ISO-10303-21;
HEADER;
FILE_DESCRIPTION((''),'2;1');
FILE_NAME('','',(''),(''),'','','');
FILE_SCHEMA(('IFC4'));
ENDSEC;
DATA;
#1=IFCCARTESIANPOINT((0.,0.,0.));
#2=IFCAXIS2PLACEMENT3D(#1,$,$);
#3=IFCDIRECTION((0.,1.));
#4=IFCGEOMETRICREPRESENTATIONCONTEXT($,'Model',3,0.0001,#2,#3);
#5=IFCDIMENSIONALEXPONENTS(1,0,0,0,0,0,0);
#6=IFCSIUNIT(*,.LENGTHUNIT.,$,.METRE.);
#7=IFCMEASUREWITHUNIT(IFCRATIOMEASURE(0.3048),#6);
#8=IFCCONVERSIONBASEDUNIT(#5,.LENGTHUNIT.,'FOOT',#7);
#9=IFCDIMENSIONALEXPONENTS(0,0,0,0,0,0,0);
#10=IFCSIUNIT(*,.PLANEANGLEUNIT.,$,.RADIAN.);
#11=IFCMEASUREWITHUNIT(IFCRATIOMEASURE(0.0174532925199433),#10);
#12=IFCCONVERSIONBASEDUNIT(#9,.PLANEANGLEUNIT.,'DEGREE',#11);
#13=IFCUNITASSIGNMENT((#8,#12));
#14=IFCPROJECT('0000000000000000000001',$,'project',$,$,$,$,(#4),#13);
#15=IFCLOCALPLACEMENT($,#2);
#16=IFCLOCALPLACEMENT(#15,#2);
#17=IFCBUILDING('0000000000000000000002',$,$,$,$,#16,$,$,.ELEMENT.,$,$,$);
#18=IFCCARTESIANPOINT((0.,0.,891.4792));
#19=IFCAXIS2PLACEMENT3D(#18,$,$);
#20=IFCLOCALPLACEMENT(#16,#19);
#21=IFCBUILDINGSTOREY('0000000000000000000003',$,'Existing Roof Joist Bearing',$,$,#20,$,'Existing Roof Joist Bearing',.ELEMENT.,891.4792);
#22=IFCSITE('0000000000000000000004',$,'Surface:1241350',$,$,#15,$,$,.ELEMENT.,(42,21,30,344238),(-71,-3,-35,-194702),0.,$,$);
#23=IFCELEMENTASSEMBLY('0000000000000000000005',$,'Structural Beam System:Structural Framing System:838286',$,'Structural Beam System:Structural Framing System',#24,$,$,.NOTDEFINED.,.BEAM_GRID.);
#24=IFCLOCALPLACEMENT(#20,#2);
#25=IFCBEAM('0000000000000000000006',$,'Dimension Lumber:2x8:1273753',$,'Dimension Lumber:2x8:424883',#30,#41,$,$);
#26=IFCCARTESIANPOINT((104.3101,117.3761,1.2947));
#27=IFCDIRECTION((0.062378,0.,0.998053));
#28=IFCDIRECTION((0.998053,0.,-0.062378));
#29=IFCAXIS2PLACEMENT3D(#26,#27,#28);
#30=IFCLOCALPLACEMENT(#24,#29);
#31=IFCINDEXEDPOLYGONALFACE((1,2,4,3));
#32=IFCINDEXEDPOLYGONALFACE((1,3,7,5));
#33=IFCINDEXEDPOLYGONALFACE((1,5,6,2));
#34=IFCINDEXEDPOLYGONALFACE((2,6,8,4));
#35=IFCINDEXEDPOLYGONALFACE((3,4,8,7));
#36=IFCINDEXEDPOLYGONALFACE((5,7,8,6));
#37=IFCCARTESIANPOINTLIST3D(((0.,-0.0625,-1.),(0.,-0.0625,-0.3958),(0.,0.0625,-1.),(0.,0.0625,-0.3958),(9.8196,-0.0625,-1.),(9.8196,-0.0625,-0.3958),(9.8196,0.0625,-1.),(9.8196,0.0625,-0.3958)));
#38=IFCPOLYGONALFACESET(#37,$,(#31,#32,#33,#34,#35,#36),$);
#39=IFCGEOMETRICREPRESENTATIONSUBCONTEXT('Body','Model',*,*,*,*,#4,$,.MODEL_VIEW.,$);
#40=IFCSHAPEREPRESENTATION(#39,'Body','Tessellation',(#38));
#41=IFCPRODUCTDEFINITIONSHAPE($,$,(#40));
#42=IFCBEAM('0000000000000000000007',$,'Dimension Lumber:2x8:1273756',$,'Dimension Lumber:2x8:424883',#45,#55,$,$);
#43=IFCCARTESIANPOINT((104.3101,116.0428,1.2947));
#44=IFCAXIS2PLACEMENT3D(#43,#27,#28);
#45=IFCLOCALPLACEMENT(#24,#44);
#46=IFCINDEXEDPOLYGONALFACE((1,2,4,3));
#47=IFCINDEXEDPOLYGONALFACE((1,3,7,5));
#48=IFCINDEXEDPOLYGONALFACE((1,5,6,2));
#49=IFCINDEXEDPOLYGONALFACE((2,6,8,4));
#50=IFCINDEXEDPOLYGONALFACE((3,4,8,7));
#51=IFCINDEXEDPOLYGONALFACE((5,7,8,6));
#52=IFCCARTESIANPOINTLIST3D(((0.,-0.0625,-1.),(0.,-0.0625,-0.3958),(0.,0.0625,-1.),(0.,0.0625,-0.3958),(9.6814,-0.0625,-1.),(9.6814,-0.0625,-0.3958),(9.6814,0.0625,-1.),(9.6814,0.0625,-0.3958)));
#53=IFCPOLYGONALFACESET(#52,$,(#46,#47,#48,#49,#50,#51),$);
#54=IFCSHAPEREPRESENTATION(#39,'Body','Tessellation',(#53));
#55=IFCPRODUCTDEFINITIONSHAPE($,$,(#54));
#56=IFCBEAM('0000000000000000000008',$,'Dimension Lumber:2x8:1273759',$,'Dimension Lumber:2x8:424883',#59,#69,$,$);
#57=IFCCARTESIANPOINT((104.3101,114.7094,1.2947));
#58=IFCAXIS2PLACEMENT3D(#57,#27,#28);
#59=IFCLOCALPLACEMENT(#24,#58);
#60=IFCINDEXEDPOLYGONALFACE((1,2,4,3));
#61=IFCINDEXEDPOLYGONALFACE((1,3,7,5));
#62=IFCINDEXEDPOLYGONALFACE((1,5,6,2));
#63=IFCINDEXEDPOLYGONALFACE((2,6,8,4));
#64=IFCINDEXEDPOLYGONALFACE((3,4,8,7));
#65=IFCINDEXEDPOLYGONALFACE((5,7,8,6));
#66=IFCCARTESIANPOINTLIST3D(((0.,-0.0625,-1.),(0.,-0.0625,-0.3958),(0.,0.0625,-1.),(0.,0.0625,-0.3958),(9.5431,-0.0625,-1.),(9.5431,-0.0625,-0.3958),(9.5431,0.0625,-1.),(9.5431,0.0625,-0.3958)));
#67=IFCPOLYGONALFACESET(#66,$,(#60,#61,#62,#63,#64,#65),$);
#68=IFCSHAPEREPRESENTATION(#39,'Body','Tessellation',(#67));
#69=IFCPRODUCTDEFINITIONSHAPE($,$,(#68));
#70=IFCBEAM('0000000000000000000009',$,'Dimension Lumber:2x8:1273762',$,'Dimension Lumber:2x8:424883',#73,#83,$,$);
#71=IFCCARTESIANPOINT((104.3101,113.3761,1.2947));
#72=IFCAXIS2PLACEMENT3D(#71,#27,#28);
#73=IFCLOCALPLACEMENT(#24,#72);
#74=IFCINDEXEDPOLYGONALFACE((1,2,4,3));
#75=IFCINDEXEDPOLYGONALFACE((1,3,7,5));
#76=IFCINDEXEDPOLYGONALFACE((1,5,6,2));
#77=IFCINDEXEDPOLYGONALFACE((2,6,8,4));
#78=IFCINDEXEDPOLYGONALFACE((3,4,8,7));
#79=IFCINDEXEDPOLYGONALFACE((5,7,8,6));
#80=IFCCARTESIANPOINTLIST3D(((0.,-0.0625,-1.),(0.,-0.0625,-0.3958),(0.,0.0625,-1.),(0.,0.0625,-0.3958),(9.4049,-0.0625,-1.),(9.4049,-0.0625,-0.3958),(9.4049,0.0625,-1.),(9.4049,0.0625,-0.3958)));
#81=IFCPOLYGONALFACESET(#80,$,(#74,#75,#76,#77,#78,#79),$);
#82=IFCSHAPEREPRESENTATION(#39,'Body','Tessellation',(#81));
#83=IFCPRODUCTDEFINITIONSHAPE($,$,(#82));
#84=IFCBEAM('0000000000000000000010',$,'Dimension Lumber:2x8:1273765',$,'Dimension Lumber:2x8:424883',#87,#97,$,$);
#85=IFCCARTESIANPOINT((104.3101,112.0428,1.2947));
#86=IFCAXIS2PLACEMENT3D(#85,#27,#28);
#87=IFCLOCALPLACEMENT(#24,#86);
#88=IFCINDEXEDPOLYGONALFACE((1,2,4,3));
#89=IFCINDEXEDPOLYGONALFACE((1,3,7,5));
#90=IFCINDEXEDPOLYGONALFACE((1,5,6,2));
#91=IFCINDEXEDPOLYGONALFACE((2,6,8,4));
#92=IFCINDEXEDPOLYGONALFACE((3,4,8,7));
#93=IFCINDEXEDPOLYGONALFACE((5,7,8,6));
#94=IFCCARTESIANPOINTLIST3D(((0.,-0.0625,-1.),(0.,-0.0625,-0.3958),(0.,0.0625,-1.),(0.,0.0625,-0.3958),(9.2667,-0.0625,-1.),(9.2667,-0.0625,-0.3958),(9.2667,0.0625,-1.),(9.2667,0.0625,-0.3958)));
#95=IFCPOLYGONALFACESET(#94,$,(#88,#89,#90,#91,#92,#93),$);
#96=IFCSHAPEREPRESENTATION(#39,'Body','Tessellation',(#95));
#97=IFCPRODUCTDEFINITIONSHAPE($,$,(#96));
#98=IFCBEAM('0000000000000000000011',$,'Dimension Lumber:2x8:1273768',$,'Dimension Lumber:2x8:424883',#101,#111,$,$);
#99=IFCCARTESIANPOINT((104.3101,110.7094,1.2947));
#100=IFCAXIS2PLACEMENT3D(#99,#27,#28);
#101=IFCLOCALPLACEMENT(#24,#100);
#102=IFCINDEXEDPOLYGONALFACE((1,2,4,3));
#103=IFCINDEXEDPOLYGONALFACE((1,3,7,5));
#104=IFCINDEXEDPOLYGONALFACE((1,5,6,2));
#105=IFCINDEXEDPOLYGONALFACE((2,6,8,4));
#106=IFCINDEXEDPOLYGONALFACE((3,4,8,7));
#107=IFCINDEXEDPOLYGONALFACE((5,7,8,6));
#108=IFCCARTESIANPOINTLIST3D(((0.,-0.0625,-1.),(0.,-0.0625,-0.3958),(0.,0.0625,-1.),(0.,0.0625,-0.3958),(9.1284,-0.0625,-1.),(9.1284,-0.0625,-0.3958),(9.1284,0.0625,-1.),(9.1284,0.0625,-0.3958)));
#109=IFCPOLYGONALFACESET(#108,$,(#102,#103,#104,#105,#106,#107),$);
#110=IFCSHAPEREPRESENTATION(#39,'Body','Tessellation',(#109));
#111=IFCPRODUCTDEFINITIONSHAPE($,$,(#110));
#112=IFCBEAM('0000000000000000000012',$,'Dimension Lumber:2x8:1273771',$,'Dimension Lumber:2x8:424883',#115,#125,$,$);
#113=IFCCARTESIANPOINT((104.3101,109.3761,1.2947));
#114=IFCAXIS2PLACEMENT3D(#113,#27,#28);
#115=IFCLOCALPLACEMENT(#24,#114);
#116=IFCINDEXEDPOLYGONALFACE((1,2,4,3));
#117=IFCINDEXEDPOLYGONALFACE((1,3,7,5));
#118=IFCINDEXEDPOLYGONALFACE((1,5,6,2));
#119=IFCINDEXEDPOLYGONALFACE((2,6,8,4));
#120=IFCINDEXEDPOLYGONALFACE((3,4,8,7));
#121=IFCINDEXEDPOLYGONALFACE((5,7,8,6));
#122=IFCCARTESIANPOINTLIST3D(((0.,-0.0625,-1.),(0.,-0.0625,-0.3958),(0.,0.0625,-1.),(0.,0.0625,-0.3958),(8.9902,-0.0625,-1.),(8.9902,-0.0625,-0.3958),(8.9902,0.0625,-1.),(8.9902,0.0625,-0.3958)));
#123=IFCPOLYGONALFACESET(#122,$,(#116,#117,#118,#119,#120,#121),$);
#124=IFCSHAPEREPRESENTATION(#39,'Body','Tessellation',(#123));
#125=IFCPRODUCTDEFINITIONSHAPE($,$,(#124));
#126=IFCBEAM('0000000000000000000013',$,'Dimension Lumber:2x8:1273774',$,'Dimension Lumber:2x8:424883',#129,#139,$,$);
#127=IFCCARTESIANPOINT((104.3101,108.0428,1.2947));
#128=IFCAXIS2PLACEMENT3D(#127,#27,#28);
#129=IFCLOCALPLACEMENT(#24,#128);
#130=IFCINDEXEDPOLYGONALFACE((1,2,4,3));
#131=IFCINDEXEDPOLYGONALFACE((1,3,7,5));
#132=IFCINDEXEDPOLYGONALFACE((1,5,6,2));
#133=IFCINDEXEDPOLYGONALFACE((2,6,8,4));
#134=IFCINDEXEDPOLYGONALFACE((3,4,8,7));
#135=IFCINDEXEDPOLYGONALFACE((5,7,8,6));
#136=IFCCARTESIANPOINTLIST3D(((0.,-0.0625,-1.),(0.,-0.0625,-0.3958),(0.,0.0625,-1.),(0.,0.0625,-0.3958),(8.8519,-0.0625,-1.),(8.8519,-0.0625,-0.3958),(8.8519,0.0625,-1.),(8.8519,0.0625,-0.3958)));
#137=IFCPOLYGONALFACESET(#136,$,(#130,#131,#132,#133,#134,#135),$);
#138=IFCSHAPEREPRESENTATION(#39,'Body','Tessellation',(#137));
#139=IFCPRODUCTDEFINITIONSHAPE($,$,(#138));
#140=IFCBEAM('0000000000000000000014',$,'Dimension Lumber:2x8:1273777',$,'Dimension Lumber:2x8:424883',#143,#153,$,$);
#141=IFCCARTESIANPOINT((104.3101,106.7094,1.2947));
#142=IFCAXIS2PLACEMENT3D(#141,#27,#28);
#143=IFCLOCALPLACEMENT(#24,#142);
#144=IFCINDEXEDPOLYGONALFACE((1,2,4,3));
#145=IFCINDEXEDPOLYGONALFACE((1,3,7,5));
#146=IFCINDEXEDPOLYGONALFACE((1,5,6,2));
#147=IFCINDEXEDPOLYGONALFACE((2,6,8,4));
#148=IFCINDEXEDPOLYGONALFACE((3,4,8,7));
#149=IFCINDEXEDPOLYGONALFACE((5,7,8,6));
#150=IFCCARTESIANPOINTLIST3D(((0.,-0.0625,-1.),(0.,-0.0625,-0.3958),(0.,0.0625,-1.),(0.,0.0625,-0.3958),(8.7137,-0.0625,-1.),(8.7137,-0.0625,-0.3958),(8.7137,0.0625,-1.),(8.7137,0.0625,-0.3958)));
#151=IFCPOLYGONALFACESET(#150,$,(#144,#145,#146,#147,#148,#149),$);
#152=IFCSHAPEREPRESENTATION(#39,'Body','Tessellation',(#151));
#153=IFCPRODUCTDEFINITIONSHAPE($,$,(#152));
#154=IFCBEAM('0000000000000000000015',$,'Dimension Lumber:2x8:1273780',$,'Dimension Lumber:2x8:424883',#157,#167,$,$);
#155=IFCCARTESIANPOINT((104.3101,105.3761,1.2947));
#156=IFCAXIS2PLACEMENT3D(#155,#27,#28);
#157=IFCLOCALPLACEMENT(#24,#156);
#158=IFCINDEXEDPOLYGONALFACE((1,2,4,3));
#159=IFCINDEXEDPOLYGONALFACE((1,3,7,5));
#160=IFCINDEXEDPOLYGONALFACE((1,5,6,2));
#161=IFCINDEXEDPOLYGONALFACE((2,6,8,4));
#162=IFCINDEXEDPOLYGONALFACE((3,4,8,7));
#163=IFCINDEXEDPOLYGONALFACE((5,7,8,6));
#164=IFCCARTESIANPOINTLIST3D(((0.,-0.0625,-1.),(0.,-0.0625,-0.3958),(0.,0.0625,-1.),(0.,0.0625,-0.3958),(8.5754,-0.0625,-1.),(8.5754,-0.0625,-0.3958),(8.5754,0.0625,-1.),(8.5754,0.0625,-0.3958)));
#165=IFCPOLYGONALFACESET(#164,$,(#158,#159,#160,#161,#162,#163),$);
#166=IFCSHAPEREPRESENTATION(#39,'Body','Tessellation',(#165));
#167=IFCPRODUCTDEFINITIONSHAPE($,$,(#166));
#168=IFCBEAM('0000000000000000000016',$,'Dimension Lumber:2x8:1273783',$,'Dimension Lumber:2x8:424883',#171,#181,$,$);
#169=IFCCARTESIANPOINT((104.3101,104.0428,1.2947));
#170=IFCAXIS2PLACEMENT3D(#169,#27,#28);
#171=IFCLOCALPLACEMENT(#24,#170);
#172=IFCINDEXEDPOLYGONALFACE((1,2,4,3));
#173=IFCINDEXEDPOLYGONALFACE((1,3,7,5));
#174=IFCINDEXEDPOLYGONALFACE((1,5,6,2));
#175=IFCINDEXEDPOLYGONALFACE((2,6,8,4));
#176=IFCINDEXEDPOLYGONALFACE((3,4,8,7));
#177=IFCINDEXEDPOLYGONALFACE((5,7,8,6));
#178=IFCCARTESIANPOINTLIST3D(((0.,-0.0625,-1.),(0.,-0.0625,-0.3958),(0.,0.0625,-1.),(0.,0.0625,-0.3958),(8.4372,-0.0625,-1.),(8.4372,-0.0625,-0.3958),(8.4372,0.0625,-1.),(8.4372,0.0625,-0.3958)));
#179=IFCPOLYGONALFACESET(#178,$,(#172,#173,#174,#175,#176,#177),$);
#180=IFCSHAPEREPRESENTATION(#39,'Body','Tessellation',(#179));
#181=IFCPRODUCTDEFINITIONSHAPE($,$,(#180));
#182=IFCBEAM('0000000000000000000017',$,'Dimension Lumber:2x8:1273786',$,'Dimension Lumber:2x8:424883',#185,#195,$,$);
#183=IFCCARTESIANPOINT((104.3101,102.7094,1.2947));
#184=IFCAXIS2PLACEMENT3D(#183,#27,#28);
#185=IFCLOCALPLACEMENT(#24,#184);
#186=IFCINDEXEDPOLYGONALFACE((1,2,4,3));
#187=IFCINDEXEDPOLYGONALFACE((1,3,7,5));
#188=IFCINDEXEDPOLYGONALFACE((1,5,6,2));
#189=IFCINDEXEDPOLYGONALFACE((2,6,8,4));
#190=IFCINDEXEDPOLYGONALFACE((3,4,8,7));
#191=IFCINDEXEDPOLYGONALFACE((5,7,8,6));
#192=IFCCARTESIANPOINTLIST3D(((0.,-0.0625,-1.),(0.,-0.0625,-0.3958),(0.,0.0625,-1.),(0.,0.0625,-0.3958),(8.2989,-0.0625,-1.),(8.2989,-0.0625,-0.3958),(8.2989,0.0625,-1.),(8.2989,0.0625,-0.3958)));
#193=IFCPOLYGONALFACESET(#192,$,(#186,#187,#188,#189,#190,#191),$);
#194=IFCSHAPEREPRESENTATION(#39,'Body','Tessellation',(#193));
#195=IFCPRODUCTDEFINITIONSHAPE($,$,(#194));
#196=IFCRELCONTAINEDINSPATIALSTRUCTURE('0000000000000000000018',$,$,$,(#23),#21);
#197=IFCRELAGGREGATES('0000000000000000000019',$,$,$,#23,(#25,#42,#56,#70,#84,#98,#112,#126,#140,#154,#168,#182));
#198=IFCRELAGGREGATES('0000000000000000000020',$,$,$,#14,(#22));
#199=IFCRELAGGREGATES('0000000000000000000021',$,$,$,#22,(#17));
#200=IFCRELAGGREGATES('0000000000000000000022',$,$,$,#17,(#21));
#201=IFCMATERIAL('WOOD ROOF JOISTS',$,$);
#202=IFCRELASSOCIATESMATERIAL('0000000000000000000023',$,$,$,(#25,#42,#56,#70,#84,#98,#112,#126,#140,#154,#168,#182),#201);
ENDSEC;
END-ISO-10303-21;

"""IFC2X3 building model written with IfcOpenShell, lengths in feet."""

from ifc_helpers import new_model, entity, si_unit, converted_unit, direction, frame, frame_2d, origin, place, context, subcontext, project, spatial, rectangle, extrude, material, element, aggregate, save


model = new_model("IFC2X3")

# Units and contexts
model_context = context("Model", 3, precision=0.0001, world=origin(), true_north=direction((0.0, 1.0)))
body_context = subcontext(model_context, "Body", "Model", "MODEL_VIEW")
ifc_project = project(units=[converted_unit("LENGTHUNIT", "FOOT", entity("IfcRatioMeasure", 0.3048), si_unit("LENGTHUNIT", "METRE"), dimensions=[1, 0, 0, 0, 0, 0, 0]), converted_unit("PLANEANGLEUNIT", "DEGREE", entity("IfcRatioMeasure", 0.0174532925199433), si_unit("PLANEANGLEUNIT", "RADIAN"), dimensions=[0, 0, 0, 0, 0, 0, 0])], contexts=[model_context])

# Site, building, storey
site_placement = place(None, origin())
site = spatial("IfcSite", under=ifc_project, at=site_placement, Name="Surface:1241350", CompositionType="ELEMENT", RefLatitude=(42, 21, 30, 344238), RefLongitude=(-71, -3, -35, -194702), RefElevation=0.0)
building_placement = place(site_placement, origin())
building = spatial("IfcBuilding", under=site, at=building_placement, CompositionType="ELEMENT")
storey_placement = place(building_placement, frame((0.0, 0.0, 891.4792)))
storey = spatial("IfcBuildingStorey", under=building, at=storey_placement, Name="Existing Roof Joist Bearing", LongName="Existing Roof Joist Bearing", CompositionType="ELEMENT", Elevation=891.4792)

# Element assembly, beams
assembly_1_placement = place(storey_placement, origin())
assembly_1 = element("IfcElementAssembly", 1, at=assembly_1_placement, inside=storey, Name="Structural Beam System:Structural Framing System:838286", ObjectType="Structural Beam System:Structural Framing System", AssemblyPlace="NOTDEFINED", PredefinedType="BEAM_GRID")
ifc_material_1 = material(Name="WOOD ROOF JOISTS")
beam_1_placement = place(assembly_1_placement, frame((104.3101, 117.3761, 1.2947), z_axis=(0.062378, 0.0, 0.998053), x_axis=(0.998053, 0.0, -0.062378)))
beam_1 = element("IfcBeam", 2, at=beam_1_placement, material=ifc_material_1, Name="Dimension Lumber:2x8:1273753", ObjectType="Dimension Lumber:2x8:424883", context=body_context, shape_type="SweptSolid", body=[
    extrude(rectangle(XDim=0.6042, YDim=0.125, at=frame_2d((0.0, 0.0), x_axis=(1.0, 0.0))), frame((0.0, 0.0, -0.6979), z_axis=(1.0, 0.0, 0.0), x_axis=(0.0, 0.0, -1.0)), (0.0, 0.0, 1.0), 9.8196),
])
beam_2_placement = place(assembly_1_placement, frame((104.3101, 116.0428, 1.2947), z_axis=(0.062378, 0.0, 0.998053), x_axis=(0.998053, 0.0, -0.062378)))
beam_2 = element("IfcBeam", 3, at=beam_2_placement, material=ifc_material_1, Name="Dimension Lumber:2x8:1273756", ObjectType="Dimension Lumber:2x8:424883", context=body_context, shape_type="SweptSolid", body=[
    extrude(rectangle(XDim=0.6042, YDim=0.125, at=frame_2d((0.0, 0.0), x_axis=(1.0, 0.0))), frame((0.0, 0.0, -0.6979), z_axis=(1.0, 0.0, 0.0), x_axis=(0.0, 0.0, -1.0)), (0.0, 0.0, 1.0), 9.6814),
])
beam_3_placement = place(assembly_1_placement, frame((104.3101, 114.7094, 1.2947), z_axis=(0.062378, 0.0, 0.998053), x_axis=(0.998053, 0.0, -0.062378)))
beam_3 = element("IfcBeam", 4, at=beam_3_placement, material=ifc_material_1, Name="Dimension Lumber:2x8:1273759", ObjectType="Dimension Lumber:2x8:424883", context=body_context, shape_type="SweptSolid", body=[
    extrude(rectangle(XDim=0.6042, YDim=0.125, at=frame_2d((0.0, 0.0), x_axis=(1.0, 0.0))), frame((0.0, 0.0, -0.6979), z_axis=(1.0, 0.0, 0.0), x_axis=(0.0, 0.0, -1.0)), (0.0, 0.0, 1.0), 9.5431),
])
beam_4_placement = place(assembly_1_placement, frame((104.3101, 113.3761, 1.2947), z_axis=(0.062378, 0.0, 0.998053), x_axis=(0.998053, 0.0, -0.062378)))
beam_4 = element("IfcBeam", 5, at=beam_4_placement, material=ifc_material_1, Name="Dimension Lumber:2x8:1273762", ObjectType="Dimension Lumber:2x8:424883", context=body_context, shape_type="SweptSolid", body=[
    extrude(rectangle(XDim=0.6042, YDim=0.125, at=frame_2d((0.0, 0.0), x_axis=(1.0, 0.0))), frame((0.0, 0.0, -0.6979), z_axis=(1.0, 0.0, 0.0), x_axis=(0.0, 0.0, -1.0)), (0.0, 0.0, 1.0), 9.4049),
])
beam_5_placement = place(assembly_1_placement, frame((104.3101, 112.0428, 1.2947), z_axis=(0.062378, 0.0, 0.998053), x_axis=(0.998053, 0.0, -0.062378)))
beam_5 = element("IfcBeam", 6, at=beam_5_placement, material=ifc_material_1, Name="Dimension Lumber:2x8:1273765", ObjectType="Dimension Lumber:2x8:424883", context=body_context, shape_type="SweptSolid", body=[
    extrude(rectangle(XDim=0.6042, YDim=0.125, at=frame_2d((0.0, 0.0), x_axis=(1.0, 0.0))), frame((0.0, 0.0, -0.6979), z_axis=(1.0, 0.0, 0.0), x_axis=(0.0, 0.0, -1.0)), (0.0, 0.0, 1.0), 9.2667),
])
beam_6_placement = place(assembly_1_placement, frame((104.3101, 110.7094, 1.2947), z_axis=(0.062378, 0.0, 0.998053), x_axis=(0.998053, 0.0, -0.062378)))
beam_6 = element("IfcBeam", 7, at=beam_6_placement, material=ifc_material_1, Name="Dimension Lumber:2x8:1273768", ObjectType="Dimension Lumber:2x8:424883", context=body_context, shape_type="SweptSolid", body=[
    extrude(rectangle(XDim=0.6042, YDim=0.125, at=frame_2d((0.0, 0.0), x_axis=(1.0, 0.0))), frame((0.0, 0.0, -0.6979), z_axis=(1.0, 0.0, 0.0), x_axis=(0.0, 0.0, -1.0)), (0.0, 0.0, 1.0), 9.1284),
])
beam_7_placement = place(assembly_1_placement, frame((104.3101, 109.3761, 1.2947), z_axis=(0.062378, 0.0, 0.998053), x_axis=(0.998053, 0.0, -0.062378)))
beam_7 = element("IfcBeam", 8, at=beam_7_placement, material=ifc_material_1, Name="Dimension Lumber:2x8:1273771", ObjectType="Dimension Lumber:2x8:424883", context=body_context, shape_type="SweptSolid", body=[
    extrude(rectangle(XDim=0.6042, YDim=0.125, at=frame_2d((0.0, 0.0), x_axis=(1.0, 0.0))), frame((0.0, 0.0, -0.6979), z_axis=(1.0, 0.0, 0.0), x_axis=(0.0, 0.0, -1.0)), (0.0, 0.0, 1.0), 8.9902),
])
beam_8_placement = place(assembly_1_placement, frame((104.3101, 108.0428, 1.2947), z_axis=(0.062378, 0.0, 0.998053), x_axis=(0.998053, 0.0, -0.062378)))
beam_8 = element("IfcBeam", 9, at=beam_8_placement, material=ifc_material_1, Name="Dimension Lumber:2x8:1273774", ObjectType="Dimension Lumber:2x8:424883", context=body_context, shape_type="SweptSolid", body=[
    extrude(rectangle(XDim=0.6042, YDim=0.125, at=frame_2d((0.0, 0.0), x_axis=(1.0, 0.0))), frame((0.0, 0.0, -0.6979), z_axis=(1.0, 0.0, 0.0), x_axis=(0.0, 0.0, -1.0)), (0.0, 0.0, 1.0), 8.8519),
])
beam_9_placement = place(assembly_1_placement, frame((104.3101, 106.7094, 1.2947), z_axis=(0.062378, 0.0, 0.998053), x_axis=(0.998053, 0.0, -0.062378)))
beam_9 = element("IfcBeam", 10, at=beam_9_placement, material=ifc_material_1, Name="Dimension Lumber:2x8:1273777", ObjectType="Dimension Lumber:2x8:424883", context=body_context, shape_type="SweptSolid", body=[
    extrude(rectangle(XDim=0.6042, YDim=0.125, at=frame_2d((0.0, 0.0), x_axis=(1.0, 0.0))), frame((0.0, 0.0, -0.6979), z_axis=(1.0, 0.0, 0.0), x_axis=(0.0, 0.0, -1.0)), (0.0, 0.0, 1.0), 8.7137),
])
beam_10_placement = place(assembly_1_placement, frame((104.3101, 105.3761, 1.2947), z_axis=(0.062378, 0.0, 0.998053), x_axis=(0.998053, 0.0, -0.062378)))
beam_10 = element("IfcBeam", 11, at=beam_10_placement, material=ifc_material_1, Name="Dimension Lumber:2x8:1273780", ObjectType="Dimension Lumber:2x8:424883", context=body_context, shape_type="SweptSolid", body=[
    extrude(rectangle(XDim=0.6042, YDim=0.125, at=frame_2d((0.0, 0.0), x_axis=(1.0, 0.0))), frame((0.0, 0.0, -0.6979), z_axis=(1.0, 0.0, 0.0), x_axis=(0.0, 0.0, -1.0)), (0.0, 0.0, 1.0), 8.5754),
])
beam_11_placement = place(assembly_1_placement, frame((104.3101, 104.0428, 1.2947), z_axis=(0.062378, 0.0, 0.998053), x_axis=(0.998053, 0.0, -0.062378)))
beam_11 = element("IfcBeam", 12, at=beam_11_placement, material=ifc_material_1, Name="Dimension Lumber:2x8:1273783", ObjectType="Dimension Lumber:2x8:424883", context=body_context, shape_type="SweptSolid", body=[
    extrude(rectangle(XDim=0.6042, YDim=0.125, at=frame_2d((0.0, 0.0), x_axis=(1.0, 0.0))), frame((0.0, 0.0, -0.6979), z_axis=(1.0, 0.0, 0.0), x_axis=(0.0, 0.0, -1.0)), (0.0, 0.0, 1.0), 8.4372),
])
beam_12_placement = place(assembly_1_placement, frame((104.3101, 102.7094, 1.2947), z_axis=(0.062378, 0.0, 0.998053), x_axis=(0.998053, 0.0, -0.062378)))
beam_12 = element("IfcBeam", 13, at=beam_12_placement, material=ifc_material_1, Name="Dimension Lumber:2x8:1273786", ObjectType="Dimension Lumber:2x8:424883", context=body_context, shape_type="SweptSolid", body=[
    extrude(rectangle(XDim=0.6042, YDim=0.125, at=frame_2d((0.0, 0.0), x_axis=(1.0, 0.0))), frame((0.0, 0.0, -0.6979), z_axis=(1.0, 0.0, 0.0), x_axis=(0.0, 0.0, -1.0)), (0.0, 0.0, 1.0), 8.2989),
])
aggregate(assembly_1, [beam_1, beam_2, beam_3, beam_4, beam_5, beam_6, beam_7, beam_8, beam_9, beam_10, beam_11, beam_12])

save(model, "model.ifc")
